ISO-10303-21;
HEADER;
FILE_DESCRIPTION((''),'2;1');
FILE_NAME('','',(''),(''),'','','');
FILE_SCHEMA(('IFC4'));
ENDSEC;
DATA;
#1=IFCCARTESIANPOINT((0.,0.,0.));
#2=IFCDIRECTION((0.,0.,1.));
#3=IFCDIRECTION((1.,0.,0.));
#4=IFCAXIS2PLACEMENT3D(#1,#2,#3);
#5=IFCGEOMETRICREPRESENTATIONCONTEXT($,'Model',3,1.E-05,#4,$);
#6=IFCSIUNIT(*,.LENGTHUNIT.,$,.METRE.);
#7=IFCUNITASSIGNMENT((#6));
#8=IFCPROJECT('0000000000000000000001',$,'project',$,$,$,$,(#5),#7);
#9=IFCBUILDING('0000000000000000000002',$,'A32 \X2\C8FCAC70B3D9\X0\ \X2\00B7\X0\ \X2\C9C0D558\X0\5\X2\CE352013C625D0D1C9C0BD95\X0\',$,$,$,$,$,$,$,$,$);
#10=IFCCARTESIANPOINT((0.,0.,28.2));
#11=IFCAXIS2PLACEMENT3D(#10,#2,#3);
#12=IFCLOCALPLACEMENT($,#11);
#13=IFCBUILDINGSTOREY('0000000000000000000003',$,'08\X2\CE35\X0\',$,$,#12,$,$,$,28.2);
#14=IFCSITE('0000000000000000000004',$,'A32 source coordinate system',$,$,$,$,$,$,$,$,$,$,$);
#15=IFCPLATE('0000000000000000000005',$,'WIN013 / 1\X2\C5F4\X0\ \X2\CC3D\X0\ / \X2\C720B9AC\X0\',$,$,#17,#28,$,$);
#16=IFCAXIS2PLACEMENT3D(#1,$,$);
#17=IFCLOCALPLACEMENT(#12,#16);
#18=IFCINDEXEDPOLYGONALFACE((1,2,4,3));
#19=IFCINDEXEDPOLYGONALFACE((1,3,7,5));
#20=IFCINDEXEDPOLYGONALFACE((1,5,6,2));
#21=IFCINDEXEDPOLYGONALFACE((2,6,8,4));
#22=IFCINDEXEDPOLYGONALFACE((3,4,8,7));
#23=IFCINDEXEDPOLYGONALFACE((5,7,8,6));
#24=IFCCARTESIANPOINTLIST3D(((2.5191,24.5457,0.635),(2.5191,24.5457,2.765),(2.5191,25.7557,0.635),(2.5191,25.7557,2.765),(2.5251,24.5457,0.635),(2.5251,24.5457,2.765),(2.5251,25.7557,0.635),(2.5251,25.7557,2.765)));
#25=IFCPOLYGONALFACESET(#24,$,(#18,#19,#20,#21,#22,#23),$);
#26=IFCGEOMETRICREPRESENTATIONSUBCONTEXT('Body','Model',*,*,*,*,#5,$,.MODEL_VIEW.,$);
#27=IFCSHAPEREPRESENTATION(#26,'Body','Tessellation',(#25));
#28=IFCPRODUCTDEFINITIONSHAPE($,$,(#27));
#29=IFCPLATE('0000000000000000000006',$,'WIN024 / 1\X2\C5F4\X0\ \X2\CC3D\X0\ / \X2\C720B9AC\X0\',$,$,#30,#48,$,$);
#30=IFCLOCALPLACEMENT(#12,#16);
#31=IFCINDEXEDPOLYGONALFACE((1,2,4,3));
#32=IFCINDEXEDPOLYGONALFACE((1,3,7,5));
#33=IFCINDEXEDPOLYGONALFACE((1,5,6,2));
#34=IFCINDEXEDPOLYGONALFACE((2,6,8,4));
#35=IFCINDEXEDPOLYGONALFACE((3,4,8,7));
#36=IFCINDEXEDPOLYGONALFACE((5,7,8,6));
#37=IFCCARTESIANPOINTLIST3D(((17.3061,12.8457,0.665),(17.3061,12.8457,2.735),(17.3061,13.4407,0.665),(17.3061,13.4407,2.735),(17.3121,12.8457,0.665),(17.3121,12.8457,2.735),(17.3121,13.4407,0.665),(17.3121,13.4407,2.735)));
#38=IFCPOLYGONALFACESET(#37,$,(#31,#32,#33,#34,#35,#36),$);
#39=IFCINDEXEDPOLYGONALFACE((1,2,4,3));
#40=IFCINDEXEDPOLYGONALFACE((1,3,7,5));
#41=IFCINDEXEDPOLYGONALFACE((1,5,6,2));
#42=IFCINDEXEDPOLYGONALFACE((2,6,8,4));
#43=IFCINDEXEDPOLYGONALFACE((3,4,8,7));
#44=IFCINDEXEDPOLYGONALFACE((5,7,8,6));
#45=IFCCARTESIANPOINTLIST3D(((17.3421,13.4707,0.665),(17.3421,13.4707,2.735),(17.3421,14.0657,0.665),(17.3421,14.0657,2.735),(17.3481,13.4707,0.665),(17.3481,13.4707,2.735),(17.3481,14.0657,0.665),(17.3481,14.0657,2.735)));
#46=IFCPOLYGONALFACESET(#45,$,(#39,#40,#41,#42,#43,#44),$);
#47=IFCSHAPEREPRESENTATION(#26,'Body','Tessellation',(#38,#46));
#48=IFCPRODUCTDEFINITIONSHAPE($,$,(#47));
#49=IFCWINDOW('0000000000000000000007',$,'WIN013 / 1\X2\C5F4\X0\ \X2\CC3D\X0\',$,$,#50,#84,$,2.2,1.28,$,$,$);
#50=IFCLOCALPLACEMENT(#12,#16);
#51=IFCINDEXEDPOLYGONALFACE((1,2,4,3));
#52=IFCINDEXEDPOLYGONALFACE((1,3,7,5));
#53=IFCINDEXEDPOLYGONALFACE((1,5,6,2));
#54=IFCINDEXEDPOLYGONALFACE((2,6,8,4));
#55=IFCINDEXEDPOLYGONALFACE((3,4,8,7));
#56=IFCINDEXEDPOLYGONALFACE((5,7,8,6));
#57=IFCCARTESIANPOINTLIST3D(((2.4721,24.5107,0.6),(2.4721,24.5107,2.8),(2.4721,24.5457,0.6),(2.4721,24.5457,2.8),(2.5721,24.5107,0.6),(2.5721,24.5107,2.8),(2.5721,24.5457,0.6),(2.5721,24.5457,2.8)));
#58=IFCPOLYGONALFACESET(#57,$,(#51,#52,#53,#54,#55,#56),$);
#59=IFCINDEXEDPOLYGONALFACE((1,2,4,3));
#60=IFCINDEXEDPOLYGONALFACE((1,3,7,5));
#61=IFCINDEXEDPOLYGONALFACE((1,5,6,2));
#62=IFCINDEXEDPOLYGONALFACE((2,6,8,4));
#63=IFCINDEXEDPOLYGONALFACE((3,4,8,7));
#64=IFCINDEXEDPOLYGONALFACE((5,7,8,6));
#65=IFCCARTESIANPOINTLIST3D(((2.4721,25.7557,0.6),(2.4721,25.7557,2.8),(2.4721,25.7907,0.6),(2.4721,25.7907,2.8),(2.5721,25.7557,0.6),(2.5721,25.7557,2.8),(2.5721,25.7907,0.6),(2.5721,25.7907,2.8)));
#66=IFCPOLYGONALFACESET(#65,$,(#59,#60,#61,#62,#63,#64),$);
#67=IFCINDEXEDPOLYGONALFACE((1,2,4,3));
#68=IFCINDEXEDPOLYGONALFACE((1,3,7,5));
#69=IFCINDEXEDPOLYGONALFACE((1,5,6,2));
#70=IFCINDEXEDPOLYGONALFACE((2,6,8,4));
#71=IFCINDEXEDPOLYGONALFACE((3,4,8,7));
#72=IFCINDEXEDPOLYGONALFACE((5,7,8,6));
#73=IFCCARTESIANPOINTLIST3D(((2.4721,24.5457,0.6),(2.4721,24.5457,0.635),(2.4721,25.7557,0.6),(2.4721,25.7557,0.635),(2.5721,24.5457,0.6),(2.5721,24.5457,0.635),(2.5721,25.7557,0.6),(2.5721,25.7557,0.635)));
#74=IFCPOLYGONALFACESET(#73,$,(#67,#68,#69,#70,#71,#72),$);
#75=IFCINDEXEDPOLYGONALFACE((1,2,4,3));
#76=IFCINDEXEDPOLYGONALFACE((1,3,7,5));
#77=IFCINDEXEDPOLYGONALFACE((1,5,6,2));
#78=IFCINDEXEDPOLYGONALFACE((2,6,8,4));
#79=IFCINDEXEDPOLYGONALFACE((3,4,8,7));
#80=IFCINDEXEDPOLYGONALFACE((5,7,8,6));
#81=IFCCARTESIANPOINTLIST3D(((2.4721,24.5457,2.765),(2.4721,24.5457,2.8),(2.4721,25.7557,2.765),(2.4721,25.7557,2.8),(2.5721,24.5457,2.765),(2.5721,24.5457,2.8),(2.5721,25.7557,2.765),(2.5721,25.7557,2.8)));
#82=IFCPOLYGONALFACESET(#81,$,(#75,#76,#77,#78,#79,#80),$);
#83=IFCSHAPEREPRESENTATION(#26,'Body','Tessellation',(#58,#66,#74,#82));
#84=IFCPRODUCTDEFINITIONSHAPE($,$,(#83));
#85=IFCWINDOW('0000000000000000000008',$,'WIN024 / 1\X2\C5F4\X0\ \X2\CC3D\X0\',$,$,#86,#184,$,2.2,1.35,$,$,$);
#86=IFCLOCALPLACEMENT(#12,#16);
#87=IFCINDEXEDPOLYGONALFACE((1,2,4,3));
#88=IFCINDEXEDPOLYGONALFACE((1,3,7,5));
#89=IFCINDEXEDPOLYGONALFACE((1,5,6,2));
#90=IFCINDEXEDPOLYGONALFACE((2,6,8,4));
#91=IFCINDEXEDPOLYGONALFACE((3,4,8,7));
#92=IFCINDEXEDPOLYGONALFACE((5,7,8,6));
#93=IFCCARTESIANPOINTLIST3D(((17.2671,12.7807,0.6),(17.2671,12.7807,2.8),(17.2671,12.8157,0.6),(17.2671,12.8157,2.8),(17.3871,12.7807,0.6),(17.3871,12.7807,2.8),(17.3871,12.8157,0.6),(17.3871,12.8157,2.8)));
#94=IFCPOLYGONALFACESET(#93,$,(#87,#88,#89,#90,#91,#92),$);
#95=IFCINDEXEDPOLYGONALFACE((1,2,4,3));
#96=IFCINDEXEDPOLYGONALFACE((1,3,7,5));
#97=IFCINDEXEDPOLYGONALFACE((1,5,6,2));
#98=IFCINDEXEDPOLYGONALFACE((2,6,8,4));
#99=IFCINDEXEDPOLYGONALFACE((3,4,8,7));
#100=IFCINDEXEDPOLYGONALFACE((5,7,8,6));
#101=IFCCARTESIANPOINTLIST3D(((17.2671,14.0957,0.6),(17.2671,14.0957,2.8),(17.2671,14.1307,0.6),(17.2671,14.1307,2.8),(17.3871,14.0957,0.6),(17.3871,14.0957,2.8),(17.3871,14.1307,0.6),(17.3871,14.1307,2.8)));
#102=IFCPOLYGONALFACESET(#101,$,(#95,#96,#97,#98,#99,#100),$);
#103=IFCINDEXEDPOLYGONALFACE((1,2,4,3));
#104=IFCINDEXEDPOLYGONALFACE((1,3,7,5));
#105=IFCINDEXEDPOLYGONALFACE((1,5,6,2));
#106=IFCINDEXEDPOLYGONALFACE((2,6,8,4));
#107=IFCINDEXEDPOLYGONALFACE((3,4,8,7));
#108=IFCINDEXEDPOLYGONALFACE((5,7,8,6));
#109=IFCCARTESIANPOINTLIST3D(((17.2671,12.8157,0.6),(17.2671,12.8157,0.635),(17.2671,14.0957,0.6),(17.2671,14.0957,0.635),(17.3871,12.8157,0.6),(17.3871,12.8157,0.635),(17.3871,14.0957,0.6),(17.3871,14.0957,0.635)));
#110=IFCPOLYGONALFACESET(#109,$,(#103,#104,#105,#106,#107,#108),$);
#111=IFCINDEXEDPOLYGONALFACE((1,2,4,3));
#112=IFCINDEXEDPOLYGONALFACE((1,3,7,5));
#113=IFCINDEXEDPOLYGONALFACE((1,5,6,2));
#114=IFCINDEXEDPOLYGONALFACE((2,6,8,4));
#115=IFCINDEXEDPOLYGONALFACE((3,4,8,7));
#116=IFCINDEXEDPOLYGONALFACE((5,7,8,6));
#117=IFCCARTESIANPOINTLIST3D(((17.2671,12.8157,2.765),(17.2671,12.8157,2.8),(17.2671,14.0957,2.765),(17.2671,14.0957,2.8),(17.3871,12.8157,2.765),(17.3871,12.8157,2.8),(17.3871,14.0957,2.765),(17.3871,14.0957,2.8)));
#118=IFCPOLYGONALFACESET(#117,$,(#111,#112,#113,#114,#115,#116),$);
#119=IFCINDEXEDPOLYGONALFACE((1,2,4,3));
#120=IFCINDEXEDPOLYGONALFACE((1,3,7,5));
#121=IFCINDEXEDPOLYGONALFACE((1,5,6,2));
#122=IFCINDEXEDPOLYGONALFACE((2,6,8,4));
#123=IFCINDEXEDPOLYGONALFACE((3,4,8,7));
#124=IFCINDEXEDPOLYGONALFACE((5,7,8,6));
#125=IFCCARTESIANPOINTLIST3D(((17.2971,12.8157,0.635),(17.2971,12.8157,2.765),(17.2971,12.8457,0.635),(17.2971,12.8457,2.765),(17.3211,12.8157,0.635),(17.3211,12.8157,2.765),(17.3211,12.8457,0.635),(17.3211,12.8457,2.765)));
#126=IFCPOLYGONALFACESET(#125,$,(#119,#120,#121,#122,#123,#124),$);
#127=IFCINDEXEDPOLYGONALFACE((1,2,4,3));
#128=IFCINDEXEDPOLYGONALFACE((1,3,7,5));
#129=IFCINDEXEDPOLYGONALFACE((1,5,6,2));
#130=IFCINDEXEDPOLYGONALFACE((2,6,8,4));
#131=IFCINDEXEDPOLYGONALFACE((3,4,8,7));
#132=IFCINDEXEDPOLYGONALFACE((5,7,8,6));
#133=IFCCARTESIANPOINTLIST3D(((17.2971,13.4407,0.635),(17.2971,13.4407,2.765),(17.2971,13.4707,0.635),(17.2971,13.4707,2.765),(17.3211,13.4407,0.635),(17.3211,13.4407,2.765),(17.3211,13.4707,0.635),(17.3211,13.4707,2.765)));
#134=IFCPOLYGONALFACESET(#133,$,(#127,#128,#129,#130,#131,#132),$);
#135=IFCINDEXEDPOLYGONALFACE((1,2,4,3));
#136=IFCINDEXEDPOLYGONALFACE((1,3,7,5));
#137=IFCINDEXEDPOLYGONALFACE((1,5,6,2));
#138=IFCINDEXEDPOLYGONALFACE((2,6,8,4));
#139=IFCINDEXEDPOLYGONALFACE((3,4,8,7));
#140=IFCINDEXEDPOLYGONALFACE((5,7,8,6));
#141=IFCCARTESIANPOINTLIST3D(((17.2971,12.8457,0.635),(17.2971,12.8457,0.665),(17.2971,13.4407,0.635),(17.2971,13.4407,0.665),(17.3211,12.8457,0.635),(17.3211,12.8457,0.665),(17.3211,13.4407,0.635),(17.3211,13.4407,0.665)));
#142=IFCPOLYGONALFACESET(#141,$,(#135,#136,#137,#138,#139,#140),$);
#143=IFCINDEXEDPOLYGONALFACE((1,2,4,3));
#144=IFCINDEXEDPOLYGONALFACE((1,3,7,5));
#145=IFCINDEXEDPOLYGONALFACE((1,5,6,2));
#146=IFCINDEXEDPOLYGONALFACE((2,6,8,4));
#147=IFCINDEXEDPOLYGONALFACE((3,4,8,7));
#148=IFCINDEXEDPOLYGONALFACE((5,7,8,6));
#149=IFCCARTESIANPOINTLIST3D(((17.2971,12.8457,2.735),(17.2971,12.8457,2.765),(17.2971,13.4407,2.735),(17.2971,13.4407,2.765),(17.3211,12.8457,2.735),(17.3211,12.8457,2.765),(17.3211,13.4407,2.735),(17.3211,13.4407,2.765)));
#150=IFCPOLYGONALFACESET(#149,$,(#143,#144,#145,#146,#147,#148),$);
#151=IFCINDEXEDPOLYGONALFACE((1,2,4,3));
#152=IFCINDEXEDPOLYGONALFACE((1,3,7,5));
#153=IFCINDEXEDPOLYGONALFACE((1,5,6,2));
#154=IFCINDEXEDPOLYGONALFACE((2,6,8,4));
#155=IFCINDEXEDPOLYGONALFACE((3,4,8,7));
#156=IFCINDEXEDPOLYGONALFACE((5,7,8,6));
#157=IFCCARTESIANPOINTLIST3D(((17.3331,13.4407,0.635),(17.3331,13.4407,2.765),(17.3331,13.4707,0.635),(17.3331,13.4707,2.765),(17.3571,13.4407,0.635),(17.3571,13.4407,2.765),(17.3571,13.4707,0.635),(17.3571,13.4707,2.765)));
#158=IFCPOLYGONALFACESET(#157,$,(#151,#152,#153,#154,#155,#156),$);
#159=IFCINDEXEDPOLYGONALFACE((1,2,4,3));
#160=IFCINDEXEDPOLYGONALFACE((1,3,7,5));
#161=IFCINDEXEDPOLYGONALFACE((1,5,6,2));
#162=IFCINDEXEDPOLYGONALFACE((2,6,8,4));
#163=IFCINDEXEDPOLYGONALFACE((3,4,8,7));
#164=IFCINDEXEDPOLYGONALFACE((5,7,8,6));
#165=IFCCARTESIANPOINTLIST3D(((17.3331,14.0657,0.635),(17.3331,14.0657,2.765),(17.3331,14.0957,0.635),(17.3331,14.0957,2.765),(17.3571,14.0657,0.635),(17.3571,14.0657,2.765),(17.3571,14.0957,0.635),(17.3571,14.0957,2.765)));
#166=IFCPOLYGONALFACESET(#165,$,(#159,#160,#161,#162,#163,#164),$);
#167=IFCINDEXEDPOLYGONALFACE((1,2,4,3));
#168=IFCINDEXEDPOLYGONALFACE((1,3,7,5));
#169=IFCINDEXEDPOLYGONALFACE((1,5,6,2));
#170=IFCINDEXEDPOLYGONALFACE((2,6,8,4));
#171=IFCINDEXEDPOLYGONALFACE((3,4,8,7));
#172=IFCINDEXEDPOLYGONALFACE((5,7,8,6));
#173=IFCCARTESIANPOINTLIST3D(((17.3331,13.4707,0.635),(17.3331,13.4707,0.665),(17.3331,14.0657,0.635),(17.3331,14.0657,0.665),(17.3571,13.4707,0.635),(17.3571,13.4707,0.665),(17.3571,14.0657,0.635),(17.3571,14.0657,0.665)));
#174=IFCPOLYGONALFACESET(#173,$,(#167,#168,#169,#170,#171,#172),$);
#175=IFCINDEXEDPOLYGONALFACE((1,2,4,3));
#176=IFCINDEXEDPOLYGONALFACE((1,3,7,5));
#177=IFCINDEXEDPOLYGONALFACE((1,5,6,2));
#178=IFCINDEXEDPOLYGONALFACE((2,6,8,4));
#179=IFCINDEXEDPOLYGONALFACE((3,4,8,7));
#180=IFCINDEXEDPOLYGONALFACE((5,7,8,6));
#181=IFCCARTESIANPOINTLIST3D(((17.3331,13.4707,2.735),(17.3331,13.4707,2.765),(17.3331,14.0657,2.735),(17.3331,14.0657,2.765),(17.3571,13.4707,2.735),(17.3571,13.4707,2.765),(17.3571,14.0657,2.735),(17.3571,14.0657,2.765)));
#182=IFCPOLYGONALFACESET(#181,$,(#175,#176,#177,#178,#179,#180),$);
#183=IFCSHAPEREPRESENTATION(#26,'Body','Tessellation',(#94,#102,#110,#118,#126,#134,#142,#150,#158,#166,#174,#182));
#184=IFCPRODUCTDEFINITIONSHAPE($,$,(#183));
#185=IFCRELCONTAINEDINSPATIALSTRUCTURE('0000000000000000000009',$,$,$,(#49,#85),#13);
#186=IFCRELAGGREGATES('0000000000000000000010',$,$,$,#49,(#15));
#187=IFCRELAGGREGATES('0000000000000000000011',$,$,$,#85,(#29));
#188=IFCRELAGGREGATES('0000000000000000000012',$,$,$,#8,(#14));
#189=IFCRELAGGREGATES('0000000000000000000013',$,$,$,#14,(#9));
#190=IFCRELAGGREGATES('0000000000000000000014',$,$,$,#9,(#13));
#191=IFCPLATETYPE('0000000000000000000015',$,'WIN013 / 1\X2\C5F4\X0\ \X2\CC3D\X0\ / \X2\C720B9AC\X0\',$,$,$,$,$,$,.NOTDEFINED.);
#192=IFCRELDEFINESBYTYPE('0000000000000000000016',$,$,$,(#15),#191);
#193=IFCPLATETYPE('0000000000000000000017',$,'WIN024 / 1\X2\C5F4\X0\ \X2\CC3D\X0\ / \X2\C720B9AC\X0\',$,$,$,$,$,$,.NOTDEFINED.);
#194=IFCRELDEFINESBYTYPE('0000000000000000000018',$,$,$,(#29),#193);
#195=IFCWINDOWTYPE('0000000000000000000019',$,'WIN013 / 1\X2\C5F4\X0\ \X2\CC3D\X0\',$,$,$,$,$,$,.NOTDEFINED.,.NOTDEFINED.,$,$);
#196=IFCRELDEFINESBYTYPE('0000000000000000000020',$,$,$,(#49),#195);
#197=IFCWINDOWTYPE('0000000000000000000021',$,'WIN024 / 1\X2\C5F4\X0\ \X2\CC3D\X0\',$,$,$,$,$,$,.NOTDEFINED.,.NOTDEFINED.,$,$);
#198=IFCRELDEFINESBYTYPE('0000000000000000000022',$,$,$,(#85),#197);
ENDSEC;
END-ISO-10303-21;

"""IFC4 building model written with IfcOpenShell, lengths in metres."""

from ifc_helpers import new_model, si_unit, frame, origin, origin_with_axes, place, context, subcontext, project, spatial, polyline, outline, extrude, source, transform, mapped, type_object, type_shapes, element, aggregate, save


model = new_model("IFC4")

# Units and contexts
model_context = context("Model", 3, precision=1e-05, world=origin_with_axes())
body_context = subcontext(model_context, "Body", "Model", "MODEL_VIEW")
ifc_project = project(units=[si_unit("LENGTHUNIT", "METRE")], contexts=[model_context])

# Plates
plate_type_1 = type_object("IfcPlateType", Name="WIN013 / 1열 창 / 유리", PredefinedType="NOTDEFINED")
shared_shape_1 = source(origin(), body_context, "Body", "SweptSolid", [
    extrude(outline(polyline([(2.5191, 24.5457), (2.5191, 25.7557), (2.5251, 25.7557), (2.5251, 24.5457), (2.5191, 24.5457)])), frame((0.0, 0.0, 0.635)), (0.0, 0.0, 1.0), 2.13),
])
type_shapes(plate_type_1, [shared_shape_1])
storey_placement = place(None, frame((0.0, 0.0, 28.2), z_axis=(0.0, 0.0, 1.0), x_axis=(1.0, 0.0, 0.0)))
window_1_placement = place(storey_placement, origin_with_axes())
plate_1_placement = place(window_1_placement, origin_with_axes())
plate_1 = element("IfcPlate", 1, at=plate_1_placement, type_object=plate_type_1, Name="WIN013 / 1열 창 / 유리", context=body_context, shape_type="MappedRepresentation", body=[
    mapped(shared_shape_1, transform((0.0, 0.0, 0.0), scale=1.0)),
])
plate_type_2 = type_object("IfcPlateType", Name="WIN024 / 1열 창 / 유리", PredefinedType="NOTDEFINED")
shared_shape_2 = source(origin(), body_context, "Body", "SweptSolid", [
    extrude(outline(polyline([(17.3061, 12.8457), (17.3061, 13.4407), (17.3121, 13.4407), (17.3121, 12.8457), (17.3061, 12.8457)])), frame((0.0, 0.0, 0.665)), (0.0, 0.0, 1.0), 2.07),
    extrude(outline(polyline([(17.3421, 13.4707), (17.3421, 14.0657), (17.3481, 14.0657), (17.3481, 13.4707), (17.3421, 13.4707)])), frame((0.0, 0.0, 0.665)), (0.0, 0.0, 1.0), 2.07),
])
type_shapes(plate_type_2, [shared_shape_2])
window_2_placement = place(storey_placement, origin_with_axes())
plate_2_placement = place(window_2_placement, origin_with_axes())
plate_2 = element("IfcPlate", 2, at=plate_2_placement, type_object=plate_type_2, Name="WIN024 / 1열 창 / 유리", context=body_context, shape_type="MappedRepresentation", body=[
    mapped(shared_shape_2, transform((0.0, 0.0, 0.0), scale=1.0)),
])

# Site, building, storey
site = spatial("IfcSite", under=ifc_project, Name="A32 source coordinate system")
building = spatial("IfcBuilding", under=site, Name="A32 주거동 · 지하5층–옥탑지붕")
storey = spatial("IfcBuildingStorey", under=building, at=storey_placement, Name="08층", Elevation=28.2)

# Windows
window_type_1 = type_object("IfcWindowType", Name="WIN013 / 1열 창", PartitioningType="NOTDEFINED", PredefinedType="NOTDEFINED")
shared_shape_3 = source(origin(), body_context, "Body", "SweptSolid", [
    extrude(outline(polyline([(2.4721, 24.5107), (2.4721, 24.5457), (2.5721, 24.5457), (2.5721, 24.5107), (2.4721, 24.5107)])), frame((0.0, 0.0, 0.6)), (0.0, 0.0, 1.0), 2.2),
    extrude(outline(polyline([(2.4721, 25.7557), (2.4721, 25.7907), (2.5721, 25.7907), (2.5721, 25.7557), (2.4721, 25.7557)])), frame((0.0, 0.0, 0.6)), (0.0, 0.0, 1.0), 2.2),
    extrude(outline(polyline([(2.4721, 24.5457), (2.4721, 25.7557), (2.5721, 25.7557), (2.5721, 24.5457), (2.4721, 24.5457)])), frame((0.0, 0.0, 0.6)), (0.0, 0.0, 1.0), 0.035),
    extrude(outline(polyline([(2.4721, 24.5457), (2.4721, 25.7557), (2.5721, 25.7557), (2.5721, 24.5457), (2.4721, 24.5457)])), frame((0.0, 0.0, 2.765)), (0.0, 0.0, 1.0), 0.035),
])
type_shapes(window_type_1, [shared_shape_3])
window_1 = element("IfcWindow", 3, at=window_1_placement, inside=storey, type_object=window_type_1, Name="WIN013 / 1열 창", OverallHeight=2.2, OverallWidth=1.28, context=body_context, shape_type="MappedRepresentation", body=[
    mapped(shared_shape_3, transform((0.0, 0.0, 0.0), scale=1.0)),
])
aggregate(window_1, [plate_1])
window_type_2 = type_object("IfcWindowType", Name="WIN024 / 1열 창", PartitioningType="NOTDEFINED", PredefinedType="NOTDEFINED")
shared_shape_4 = source(origin(), body_context, "Body", "SweptSolid", [
    extrude(outline(polyline([(17.2671, 12.7807), (17.2671, 12.8157), (17.3871, 12.8157), (17.3871, 12.7807), (17.2671, 12.7807)])), frame((0.0, 0.0, 0.6)), (0.0, 0.0, 1.0), 2.2),
    extrude(outline(polyline([(17.2671, 14.0957), (17.2671, 14.1307), (17.3871, 14.1307), (17.3871, 14.0957), (17.2671, 14.0957)])), frame((0.0, 0.0, 0.6)), (0.0, 0.0, 1.0), 2.2),
    extrude(outline(polyline([(17.2671, 12.8157), (17.2671, 14.0957), (17.3871, 14.0957), (17.3871, 12.8157), (17.2671, 12.8157)])), frame((0.0, 0.0, 0.6)), (0.0, 0.0, 1.0), 0.035),
    extrude(outline(polyline([(17.2671, 12.8157), (17.2671, 14.0957), (17.3871, 14.0957), (17.3871, 12.8157), (17.2671, 12.8157)])), frame((0.0, 0.0, 2.765)), (0.0, 0.0, 1.0), 0.035),
    extrude(outline(polyline([(17.2971, 12.8157), (17.2971, 12.8457), (17.3211, 12.8457), (17.3211, 12.8157), (17.2971, 12.8157)])), frame((0.0, 0.0, 0.635)), (0.0, 0.0, 1.0), 2.13),
    extrude(outline(polyline([(17.2971, 13.4407), (17.2971, 13.4707), (17.3211, 13.4707), (17.3211, 13.4407), (17.2971, 13.4407)])), frame((0.0, 0.0, 0.635)), (0.0, 0.0, 1.0), 2.13),
    extrude(outline(polyline([(17.2971, 12.8457), (17.2971, 13.4407), (17.3211, 13.4407), (17.3211, 12.8457), (17.2971, 12.8457)])), frame((0.0, 0.0, 0.635)), (0.0, 0.0, 1.0), 0.03),
    extrude(outline(polyline([(17.2971, 12.8457), (17.2971, 13.4407), (17.3211, 13.4407), (17.3211, 12.8457), (17.2971, 12.8457)])), frame((0.0, 0.0, 2.735)), (0.0, 0.0, 1.0), 0.03),
    extrude(outline(polyline([(17.3331, 13.4407), (17.3331, 13.4707), (17.3571, 13.4707), (17.3571, 13.4407), (17.3331, 13.4407)])), frame((0.0, 0.0, 0.635)), (0.0, 0.0, 1.0), 2.13),
    extrude(outline(polyline([(17.3331, 14.0657), (17.3331, 14.0957), (17.3571, 14.0957), (17.3571, 14.0657), (17.3331, 14.0657)])), frame((0.0, 0.0, 0.635)), (0.0, 0.0, 1.0), 2.13),
    extrude(outline(polyline([(17.3331, 13.4707), (17.3331, 14.0657), (17.3571, 14.0657), (17.3571, 13.4707), (17.3331, 13.4707)])), frame((0.0, 0.0, 0.635)), (0.0, 0.0, 1.0), 0.03),
    extrude(outline(polyline([(17.3331, 13.4707), (17.3331, 14.0657), (17.3571, 14.0657), (17.3571, 13.4707), (17.3331, 13.4707)])), frame((0.0, 0.0, 2.735)), (0.0, 0.0, 1.0), 0.03),
])
type_shapes(window_type_2, [shared_shape_4])
window_2 = element("IfcWindow", 4, at=window_2_placement, inside=storey, type_object=window_type_2, Name="WIN024 / 1열 창", OverallHeight=2.2, OverallWidth=1.35, context=body_context, shape_type="MappedRepresentation", body=[
    mapped(shared_shape_4, transform((0.0, 0.0, 0.0), scale=1.0)),
])
aggregate(window_2, [plate_2])

save(model, "model.ifc")
